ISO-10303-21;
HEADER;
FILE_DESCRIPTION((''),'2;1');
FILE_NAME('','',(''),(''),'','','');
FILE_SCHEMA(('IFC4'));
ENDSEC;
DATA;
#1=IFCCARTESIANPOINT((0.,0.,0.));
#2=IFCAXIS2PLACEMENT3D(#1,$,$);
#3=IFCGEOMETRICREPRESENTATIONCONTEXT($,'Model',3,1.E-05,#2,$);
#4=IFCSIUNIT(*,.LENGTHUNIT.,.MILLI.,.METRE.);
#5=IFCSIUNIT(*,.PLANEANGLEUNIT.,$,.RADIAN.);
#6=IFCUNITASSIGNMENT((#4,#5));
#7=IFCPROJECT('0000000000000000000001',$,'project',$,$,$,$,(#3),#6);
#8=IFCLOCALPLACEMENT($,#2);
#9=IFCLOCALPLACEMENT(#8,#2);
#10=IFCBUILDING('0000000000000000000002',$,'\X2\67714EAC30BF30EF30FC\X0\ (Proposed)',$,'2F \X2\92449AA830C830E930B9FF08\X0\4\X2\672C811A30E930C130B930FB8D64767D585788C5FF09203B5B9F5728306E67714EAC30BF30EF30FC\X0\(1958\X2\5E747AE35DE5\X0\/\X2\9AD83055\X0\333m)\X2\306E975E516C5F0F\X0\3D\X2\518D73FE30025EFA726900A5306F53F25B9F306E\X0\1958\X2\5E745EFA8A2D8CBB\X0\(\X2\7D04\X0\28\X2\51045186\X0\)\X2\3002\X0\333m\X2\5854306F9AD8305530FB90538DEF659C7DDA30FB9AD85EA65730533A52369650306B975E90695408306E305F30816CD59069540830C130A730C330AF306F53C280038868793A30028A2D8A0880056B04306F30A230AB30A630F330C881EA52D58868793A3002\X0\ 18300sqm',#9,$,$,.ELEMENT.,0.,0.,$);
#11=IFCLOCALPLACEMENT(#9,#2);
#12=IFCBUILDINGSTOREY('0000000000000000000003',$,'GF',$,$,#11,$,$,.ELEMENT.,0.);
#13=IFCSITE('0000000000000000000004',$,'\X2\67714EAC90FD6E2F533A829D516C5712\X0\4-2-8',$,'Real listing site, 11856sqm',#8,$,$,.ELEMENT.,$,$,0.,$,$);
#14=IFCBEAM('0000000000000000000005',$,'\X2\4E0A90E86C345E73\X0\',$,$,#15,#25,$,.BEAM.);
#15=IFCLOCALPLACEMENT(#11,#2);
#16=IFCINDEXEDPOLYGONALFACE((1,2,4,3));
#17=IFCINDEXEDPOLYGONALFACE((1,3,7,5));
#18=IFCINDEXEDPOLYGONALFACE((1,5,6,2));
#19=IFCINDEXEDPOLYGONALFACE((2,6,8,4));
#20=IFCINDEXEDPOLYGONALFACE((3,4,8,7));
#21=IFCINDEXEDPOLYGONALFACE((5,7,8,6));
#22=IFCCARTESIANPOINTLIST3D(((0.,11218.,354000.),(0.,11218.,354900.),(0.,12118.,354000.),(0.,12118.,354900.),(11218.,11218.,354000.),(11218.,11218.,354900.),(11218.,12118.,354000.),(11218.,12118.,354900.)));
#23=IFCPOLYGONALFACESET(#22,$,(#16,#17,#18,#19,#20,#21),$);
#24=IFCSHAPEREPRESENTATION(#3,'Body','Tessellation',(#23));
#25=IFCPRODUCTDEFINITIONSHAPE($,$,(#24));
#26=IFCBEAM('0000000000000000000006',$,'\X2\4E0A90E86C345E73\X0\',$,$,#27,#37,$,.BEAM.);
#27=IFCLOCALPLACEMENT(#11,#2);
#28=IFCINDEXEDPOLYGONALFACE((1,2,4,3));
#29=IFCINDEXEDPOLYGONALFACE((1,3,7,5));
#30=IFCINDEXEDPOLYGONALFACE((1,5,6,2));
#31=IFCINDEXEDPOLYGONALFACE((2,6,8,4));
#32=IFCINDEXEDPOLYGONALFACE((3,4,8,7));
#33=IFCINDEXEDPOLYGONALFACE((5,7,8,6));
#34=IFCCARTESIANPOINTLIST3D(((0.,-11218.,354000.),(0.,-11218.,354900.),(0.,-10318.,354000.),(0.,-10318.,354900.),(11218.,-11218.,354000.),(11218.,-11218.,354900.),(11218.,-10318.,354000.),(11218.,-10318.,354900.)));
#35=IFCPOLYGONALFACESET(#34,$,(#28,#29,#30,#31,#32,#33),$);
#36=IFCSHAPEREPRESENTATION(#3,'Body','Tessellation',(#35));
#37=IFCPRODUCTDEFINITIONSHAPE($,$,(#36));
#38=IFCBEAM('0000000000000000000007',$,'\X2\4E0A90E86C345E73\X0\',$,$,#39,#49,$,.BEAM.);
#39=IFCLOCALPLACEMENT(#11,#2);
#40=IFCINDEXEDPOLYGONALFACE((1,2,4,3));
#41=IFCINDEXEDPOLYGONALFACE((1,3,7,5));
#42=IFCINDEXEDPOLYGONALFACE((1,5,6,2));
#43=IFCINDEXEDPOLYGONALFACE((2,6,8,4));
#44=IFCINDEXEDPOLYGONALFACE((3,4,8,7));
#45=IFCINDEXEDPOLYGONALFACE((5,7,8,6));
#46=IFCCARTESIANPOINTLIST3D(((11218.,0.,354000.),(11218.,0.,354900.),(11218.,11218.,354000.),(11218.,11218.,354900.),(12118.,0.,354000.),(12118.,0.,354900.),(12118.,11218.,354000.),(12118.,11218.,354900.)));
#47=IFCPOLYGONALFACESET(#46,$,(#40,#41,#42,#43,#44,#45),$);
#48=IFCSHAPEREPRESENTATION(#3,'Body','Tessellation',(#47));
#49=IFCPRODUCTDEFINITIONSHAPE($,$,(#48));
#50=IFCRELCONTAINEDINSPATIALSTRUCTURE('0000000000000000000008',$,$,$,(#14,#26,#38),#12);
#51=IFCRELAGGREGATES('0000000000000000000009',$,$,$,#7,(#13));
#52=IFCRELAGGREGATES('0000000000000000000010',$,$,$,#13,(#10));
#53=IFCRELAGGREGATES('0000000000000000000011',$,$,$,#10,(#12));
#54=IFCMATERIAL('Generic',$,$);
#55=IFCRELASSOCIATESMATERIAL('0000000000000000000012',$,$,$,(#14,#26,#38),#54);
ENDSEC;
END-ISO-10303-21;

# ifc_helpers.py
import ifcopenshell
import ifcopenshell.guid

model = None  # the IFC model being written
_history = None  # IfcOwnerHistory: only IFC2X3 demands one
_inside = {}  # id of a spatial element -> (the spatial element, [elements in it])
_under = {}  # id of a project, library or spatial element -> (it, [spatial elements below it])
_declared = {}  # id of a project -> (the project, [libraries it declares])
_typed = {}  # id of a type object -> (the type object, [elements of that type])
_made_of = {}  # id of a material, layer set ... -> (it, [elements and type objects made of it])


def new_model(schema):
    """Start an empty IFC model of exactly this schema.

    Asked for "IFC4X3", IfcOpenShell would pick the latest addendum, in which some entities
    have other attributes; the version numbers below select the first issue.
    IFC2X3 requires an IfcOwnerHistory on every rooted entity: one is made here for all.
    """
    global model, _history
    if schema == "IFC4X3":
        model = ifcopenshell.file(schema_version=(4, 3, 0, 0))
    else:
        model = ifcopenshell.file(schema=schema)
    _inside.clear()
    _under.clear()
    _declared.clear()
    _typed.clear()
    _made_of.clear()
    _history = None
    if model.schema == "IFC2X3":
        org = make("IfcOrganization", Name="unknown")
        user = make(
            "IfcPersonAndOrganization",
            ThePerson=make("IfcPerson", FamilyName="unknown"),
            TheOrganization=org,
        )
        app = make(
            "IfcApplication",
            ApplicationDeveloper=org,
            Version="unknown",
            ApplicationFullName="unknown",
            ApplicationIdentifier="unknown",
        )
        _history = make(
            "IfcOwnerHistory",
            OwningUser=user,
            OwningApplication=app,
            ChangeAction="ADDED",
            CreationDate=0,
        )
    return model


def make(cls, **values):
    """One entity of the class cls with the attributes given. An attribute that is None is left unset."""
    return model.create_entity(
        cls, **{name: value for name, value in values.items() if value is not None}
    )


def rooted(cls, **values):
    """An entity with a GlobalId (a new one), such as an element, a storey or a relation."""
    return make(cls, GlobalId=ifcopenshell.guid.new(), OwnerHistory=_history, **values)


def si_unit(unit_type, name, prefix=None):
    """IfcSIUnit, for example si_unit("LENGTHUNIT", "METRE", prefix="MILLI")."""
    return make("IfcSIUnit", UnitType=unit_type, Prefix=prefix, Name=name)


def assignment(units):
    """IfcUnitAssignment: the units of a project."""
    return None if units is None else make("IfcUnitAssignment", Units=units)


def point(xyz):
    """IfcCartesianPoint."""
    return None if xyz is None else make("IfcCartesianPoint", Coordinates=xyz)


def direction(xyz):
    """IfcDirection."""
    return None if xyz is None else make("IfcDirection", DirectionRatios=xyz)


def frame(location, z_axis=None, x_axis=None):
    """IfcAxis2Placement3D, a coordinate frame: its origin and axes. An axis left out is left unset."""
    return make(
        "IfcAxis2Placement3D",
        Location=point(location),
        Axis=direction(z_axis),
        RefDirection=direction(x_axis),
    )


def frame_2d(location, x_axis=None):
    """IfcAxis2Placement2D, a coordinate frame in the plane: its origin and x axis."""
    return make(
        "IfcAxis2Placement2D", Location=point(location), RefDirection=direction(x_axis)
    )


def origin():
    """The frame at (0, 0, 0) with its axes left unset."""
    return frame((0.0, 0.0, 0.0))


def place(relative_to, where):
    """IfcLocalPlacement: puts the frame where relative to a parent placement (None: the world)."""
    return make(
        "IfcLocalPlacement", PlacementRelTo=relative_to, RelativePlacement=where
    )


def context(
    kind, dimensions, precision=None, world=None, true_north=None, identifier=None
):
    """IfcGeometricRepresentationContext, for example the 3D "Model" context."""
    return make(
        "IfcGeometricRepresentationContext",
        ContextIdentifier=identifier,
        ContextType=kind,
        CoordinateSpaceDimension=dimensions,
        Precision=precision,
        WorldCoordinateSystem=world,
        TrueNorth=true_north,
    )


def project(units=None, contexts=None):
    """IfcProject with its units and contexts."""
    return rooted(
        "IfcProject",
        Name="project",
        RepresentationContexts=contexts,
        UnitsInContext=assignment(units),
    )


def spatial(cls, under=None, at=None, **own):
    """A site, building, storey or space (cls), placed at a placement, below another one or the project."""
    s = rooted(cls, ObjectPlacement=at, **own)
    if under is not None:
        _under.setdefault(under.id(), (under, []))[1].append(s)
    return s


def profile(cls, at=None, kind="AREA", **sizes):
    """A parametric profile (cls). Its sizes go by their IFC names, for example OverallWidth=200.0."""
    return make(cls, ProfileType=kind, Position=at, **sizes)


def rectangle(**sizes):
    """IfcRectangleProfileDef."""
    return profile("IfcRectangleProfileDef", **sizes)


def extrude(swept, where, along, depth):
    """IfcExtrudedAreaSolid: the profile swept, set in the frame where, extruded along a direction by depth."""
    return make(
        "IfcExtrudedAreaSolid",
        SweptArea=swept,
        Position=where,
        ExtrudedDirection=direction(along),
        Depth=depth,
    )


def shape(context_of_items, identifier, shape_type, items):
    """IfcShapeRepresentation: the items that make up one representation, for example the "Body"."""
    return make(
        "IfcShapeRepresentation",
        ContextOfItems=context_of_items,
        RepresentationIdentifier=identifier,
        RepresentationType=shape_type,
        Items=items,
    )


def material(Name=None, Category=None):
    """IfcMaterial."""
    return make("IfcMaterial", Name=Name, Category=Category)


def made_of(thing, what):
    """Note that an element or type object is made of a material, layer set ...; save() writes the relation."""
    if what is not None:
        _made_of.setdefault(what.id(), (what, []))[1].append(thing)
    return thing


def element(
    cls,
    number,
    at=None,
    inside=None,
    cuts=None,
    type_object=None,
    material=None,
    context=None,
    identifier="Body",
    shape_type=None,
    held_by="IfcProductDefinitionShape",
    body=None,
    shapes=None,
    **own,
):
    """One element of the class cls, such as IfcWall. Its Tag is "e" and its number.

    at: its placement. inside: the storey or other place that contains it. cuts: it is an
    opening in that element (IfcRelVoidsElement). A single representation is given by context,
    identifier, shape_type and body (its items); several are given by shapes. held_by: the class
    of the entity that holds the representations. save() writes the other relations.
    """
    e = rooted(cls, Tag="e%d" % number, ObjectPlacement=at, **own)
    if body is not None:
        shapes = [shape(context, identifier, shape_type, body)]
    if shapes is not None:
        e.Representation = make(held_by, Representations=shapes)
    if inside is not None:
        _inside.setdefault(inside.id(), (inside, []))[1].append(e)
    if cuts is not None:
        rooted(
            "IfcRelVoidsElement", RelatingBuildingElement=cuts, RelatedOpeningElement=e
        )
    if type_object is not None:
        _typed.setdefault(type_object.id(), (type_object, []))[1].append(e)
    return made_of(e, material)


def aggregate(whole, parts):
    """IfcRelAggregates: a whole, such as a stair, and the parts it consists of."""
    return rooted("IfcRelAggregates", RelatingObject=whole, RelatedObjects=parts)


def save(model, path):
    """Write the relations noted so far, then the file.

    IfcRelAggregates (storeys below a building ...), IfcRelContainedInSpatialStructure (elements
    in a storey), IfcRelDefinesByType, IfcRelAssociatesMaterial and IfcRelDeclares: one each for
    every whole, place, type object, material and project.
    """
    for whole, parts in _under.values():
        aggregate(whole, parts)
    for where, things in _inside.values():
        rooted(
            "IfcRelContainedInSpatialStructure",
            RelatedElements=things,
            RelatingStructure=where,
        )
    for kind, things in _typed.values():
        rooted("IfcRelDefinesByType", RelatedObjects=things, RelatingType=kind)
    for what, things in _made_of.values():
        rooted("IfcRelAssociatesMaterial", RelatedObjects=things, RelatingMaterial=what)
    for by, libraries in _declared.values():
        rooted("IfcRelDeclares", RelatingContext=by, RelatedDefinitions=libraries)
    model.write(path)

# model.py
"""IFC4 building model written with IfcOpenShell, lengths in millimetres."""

from ifc_helpers import new_model, si_unit, frame, frame_2d, origin, place, context, project, spatial, rectangle, extrude, material, element, save


model = new_model("IFC4")

# Units and contexts
model_context = context("Model", 3, precision=1e-05, world=origin())
ifc_project = project(units=[si_unit("LENGTHUNIT", "METRE", prefix="MILLI"), si_unit("PLANEANGLEUNIT", "RADIAN")], contexts=[model_context])

# Site, building, storey
site_placement = place(None, origin())
site = spatial("IfcSite", under=ifc_project, at=site_placement, Name="東京都港区芝公園4-2-8", ObjectType="Real listing site, 11856sqm", CompositionType="ELEMENT", RefElevation=0.0)
building_placement = place(site_placement, origin())
building = spatial("IfcBuilding", under=site, at=building_placement, Name="東京タワー (Proposed)", ObjectType="2F 鉄骨トラス（4本脚ラチス・赤白塗装）※実在の東京タワー(1958年竣工/高さ333m)の非公式3D再現。建物¥は史実の1958年建設費(約28億円)。333m塔は高さ・道路斜線・高度地区制限に非適合のため法適合チェックは参考表示。設計者欄はアカウント自動表示。 18300sqm", CompositionType="ELEMENT", ElevationOfRefHeight=0.0, ElevationOfTerrain=0.0)
storey_placement = place(building_placement, origin())
storey = spatial("IfcBuildingStorey", under=building, at=storey_placement, Name="GF", CompositionType="ELEMENT", Elevation=0.0)

# Shared definitions
ifc_material = material(Name="Generic")

# Beams
beam_1_placement = place(storey_placement, frame((0.0, 5609.0, 177000.0)))
element("IfcBeam", 1, at=beam_1_placement, inside=storey, material=ifc_material, Name="上部水平", PredefinedType="BEAM", context=model_context, shape_type="SweptSolid", body=[
    extrude(rectangle(XDim=11218.0, YDim=900.0, at=frame_2d((5609.0, 450.0))), frame((0.0, 5609.0, 177000.0)), (0.0, 0.0, 1.0), 900.0),
])
beam_2_placement = place(storey_placement, frame((0.0, -5609.0, 177000.0)))
element("IfcBeam", 2, at=beam_2_placement, inside=storey, material=ifc_material, Name="上部水平", PredefinedType="BEAM", context=model_context, shape_type="SweptSolid", body=[
    extrude(rectangle(XDim=11218.0, YDim=900.0, at=frame_2d((5609.0, 450.0))), frame((0.0, -5609.0, 177000.0)), (0.0, 0.0, 1.0), 900.0),
])
beam_3_placement = place(storey_placement, frame((5609.0, 0.0, 177000.0)))
element("IfcBeam", 3, at=beam_3_placement, inside=storey, material=ifc_material, Name="上部水平", PredefinedType="BEAM", context=model_context, shape_type="SweptSolid", body=[
    extrude(rectangle(XDim=900.0, YDim=11218.0, at=frame_2d((450.0, 5609.0))), frame((5609.0, 0.0, 177000.0)), (0.0, 0.0, 1.0), 900.0),
])

save(model, "model.ifc")
